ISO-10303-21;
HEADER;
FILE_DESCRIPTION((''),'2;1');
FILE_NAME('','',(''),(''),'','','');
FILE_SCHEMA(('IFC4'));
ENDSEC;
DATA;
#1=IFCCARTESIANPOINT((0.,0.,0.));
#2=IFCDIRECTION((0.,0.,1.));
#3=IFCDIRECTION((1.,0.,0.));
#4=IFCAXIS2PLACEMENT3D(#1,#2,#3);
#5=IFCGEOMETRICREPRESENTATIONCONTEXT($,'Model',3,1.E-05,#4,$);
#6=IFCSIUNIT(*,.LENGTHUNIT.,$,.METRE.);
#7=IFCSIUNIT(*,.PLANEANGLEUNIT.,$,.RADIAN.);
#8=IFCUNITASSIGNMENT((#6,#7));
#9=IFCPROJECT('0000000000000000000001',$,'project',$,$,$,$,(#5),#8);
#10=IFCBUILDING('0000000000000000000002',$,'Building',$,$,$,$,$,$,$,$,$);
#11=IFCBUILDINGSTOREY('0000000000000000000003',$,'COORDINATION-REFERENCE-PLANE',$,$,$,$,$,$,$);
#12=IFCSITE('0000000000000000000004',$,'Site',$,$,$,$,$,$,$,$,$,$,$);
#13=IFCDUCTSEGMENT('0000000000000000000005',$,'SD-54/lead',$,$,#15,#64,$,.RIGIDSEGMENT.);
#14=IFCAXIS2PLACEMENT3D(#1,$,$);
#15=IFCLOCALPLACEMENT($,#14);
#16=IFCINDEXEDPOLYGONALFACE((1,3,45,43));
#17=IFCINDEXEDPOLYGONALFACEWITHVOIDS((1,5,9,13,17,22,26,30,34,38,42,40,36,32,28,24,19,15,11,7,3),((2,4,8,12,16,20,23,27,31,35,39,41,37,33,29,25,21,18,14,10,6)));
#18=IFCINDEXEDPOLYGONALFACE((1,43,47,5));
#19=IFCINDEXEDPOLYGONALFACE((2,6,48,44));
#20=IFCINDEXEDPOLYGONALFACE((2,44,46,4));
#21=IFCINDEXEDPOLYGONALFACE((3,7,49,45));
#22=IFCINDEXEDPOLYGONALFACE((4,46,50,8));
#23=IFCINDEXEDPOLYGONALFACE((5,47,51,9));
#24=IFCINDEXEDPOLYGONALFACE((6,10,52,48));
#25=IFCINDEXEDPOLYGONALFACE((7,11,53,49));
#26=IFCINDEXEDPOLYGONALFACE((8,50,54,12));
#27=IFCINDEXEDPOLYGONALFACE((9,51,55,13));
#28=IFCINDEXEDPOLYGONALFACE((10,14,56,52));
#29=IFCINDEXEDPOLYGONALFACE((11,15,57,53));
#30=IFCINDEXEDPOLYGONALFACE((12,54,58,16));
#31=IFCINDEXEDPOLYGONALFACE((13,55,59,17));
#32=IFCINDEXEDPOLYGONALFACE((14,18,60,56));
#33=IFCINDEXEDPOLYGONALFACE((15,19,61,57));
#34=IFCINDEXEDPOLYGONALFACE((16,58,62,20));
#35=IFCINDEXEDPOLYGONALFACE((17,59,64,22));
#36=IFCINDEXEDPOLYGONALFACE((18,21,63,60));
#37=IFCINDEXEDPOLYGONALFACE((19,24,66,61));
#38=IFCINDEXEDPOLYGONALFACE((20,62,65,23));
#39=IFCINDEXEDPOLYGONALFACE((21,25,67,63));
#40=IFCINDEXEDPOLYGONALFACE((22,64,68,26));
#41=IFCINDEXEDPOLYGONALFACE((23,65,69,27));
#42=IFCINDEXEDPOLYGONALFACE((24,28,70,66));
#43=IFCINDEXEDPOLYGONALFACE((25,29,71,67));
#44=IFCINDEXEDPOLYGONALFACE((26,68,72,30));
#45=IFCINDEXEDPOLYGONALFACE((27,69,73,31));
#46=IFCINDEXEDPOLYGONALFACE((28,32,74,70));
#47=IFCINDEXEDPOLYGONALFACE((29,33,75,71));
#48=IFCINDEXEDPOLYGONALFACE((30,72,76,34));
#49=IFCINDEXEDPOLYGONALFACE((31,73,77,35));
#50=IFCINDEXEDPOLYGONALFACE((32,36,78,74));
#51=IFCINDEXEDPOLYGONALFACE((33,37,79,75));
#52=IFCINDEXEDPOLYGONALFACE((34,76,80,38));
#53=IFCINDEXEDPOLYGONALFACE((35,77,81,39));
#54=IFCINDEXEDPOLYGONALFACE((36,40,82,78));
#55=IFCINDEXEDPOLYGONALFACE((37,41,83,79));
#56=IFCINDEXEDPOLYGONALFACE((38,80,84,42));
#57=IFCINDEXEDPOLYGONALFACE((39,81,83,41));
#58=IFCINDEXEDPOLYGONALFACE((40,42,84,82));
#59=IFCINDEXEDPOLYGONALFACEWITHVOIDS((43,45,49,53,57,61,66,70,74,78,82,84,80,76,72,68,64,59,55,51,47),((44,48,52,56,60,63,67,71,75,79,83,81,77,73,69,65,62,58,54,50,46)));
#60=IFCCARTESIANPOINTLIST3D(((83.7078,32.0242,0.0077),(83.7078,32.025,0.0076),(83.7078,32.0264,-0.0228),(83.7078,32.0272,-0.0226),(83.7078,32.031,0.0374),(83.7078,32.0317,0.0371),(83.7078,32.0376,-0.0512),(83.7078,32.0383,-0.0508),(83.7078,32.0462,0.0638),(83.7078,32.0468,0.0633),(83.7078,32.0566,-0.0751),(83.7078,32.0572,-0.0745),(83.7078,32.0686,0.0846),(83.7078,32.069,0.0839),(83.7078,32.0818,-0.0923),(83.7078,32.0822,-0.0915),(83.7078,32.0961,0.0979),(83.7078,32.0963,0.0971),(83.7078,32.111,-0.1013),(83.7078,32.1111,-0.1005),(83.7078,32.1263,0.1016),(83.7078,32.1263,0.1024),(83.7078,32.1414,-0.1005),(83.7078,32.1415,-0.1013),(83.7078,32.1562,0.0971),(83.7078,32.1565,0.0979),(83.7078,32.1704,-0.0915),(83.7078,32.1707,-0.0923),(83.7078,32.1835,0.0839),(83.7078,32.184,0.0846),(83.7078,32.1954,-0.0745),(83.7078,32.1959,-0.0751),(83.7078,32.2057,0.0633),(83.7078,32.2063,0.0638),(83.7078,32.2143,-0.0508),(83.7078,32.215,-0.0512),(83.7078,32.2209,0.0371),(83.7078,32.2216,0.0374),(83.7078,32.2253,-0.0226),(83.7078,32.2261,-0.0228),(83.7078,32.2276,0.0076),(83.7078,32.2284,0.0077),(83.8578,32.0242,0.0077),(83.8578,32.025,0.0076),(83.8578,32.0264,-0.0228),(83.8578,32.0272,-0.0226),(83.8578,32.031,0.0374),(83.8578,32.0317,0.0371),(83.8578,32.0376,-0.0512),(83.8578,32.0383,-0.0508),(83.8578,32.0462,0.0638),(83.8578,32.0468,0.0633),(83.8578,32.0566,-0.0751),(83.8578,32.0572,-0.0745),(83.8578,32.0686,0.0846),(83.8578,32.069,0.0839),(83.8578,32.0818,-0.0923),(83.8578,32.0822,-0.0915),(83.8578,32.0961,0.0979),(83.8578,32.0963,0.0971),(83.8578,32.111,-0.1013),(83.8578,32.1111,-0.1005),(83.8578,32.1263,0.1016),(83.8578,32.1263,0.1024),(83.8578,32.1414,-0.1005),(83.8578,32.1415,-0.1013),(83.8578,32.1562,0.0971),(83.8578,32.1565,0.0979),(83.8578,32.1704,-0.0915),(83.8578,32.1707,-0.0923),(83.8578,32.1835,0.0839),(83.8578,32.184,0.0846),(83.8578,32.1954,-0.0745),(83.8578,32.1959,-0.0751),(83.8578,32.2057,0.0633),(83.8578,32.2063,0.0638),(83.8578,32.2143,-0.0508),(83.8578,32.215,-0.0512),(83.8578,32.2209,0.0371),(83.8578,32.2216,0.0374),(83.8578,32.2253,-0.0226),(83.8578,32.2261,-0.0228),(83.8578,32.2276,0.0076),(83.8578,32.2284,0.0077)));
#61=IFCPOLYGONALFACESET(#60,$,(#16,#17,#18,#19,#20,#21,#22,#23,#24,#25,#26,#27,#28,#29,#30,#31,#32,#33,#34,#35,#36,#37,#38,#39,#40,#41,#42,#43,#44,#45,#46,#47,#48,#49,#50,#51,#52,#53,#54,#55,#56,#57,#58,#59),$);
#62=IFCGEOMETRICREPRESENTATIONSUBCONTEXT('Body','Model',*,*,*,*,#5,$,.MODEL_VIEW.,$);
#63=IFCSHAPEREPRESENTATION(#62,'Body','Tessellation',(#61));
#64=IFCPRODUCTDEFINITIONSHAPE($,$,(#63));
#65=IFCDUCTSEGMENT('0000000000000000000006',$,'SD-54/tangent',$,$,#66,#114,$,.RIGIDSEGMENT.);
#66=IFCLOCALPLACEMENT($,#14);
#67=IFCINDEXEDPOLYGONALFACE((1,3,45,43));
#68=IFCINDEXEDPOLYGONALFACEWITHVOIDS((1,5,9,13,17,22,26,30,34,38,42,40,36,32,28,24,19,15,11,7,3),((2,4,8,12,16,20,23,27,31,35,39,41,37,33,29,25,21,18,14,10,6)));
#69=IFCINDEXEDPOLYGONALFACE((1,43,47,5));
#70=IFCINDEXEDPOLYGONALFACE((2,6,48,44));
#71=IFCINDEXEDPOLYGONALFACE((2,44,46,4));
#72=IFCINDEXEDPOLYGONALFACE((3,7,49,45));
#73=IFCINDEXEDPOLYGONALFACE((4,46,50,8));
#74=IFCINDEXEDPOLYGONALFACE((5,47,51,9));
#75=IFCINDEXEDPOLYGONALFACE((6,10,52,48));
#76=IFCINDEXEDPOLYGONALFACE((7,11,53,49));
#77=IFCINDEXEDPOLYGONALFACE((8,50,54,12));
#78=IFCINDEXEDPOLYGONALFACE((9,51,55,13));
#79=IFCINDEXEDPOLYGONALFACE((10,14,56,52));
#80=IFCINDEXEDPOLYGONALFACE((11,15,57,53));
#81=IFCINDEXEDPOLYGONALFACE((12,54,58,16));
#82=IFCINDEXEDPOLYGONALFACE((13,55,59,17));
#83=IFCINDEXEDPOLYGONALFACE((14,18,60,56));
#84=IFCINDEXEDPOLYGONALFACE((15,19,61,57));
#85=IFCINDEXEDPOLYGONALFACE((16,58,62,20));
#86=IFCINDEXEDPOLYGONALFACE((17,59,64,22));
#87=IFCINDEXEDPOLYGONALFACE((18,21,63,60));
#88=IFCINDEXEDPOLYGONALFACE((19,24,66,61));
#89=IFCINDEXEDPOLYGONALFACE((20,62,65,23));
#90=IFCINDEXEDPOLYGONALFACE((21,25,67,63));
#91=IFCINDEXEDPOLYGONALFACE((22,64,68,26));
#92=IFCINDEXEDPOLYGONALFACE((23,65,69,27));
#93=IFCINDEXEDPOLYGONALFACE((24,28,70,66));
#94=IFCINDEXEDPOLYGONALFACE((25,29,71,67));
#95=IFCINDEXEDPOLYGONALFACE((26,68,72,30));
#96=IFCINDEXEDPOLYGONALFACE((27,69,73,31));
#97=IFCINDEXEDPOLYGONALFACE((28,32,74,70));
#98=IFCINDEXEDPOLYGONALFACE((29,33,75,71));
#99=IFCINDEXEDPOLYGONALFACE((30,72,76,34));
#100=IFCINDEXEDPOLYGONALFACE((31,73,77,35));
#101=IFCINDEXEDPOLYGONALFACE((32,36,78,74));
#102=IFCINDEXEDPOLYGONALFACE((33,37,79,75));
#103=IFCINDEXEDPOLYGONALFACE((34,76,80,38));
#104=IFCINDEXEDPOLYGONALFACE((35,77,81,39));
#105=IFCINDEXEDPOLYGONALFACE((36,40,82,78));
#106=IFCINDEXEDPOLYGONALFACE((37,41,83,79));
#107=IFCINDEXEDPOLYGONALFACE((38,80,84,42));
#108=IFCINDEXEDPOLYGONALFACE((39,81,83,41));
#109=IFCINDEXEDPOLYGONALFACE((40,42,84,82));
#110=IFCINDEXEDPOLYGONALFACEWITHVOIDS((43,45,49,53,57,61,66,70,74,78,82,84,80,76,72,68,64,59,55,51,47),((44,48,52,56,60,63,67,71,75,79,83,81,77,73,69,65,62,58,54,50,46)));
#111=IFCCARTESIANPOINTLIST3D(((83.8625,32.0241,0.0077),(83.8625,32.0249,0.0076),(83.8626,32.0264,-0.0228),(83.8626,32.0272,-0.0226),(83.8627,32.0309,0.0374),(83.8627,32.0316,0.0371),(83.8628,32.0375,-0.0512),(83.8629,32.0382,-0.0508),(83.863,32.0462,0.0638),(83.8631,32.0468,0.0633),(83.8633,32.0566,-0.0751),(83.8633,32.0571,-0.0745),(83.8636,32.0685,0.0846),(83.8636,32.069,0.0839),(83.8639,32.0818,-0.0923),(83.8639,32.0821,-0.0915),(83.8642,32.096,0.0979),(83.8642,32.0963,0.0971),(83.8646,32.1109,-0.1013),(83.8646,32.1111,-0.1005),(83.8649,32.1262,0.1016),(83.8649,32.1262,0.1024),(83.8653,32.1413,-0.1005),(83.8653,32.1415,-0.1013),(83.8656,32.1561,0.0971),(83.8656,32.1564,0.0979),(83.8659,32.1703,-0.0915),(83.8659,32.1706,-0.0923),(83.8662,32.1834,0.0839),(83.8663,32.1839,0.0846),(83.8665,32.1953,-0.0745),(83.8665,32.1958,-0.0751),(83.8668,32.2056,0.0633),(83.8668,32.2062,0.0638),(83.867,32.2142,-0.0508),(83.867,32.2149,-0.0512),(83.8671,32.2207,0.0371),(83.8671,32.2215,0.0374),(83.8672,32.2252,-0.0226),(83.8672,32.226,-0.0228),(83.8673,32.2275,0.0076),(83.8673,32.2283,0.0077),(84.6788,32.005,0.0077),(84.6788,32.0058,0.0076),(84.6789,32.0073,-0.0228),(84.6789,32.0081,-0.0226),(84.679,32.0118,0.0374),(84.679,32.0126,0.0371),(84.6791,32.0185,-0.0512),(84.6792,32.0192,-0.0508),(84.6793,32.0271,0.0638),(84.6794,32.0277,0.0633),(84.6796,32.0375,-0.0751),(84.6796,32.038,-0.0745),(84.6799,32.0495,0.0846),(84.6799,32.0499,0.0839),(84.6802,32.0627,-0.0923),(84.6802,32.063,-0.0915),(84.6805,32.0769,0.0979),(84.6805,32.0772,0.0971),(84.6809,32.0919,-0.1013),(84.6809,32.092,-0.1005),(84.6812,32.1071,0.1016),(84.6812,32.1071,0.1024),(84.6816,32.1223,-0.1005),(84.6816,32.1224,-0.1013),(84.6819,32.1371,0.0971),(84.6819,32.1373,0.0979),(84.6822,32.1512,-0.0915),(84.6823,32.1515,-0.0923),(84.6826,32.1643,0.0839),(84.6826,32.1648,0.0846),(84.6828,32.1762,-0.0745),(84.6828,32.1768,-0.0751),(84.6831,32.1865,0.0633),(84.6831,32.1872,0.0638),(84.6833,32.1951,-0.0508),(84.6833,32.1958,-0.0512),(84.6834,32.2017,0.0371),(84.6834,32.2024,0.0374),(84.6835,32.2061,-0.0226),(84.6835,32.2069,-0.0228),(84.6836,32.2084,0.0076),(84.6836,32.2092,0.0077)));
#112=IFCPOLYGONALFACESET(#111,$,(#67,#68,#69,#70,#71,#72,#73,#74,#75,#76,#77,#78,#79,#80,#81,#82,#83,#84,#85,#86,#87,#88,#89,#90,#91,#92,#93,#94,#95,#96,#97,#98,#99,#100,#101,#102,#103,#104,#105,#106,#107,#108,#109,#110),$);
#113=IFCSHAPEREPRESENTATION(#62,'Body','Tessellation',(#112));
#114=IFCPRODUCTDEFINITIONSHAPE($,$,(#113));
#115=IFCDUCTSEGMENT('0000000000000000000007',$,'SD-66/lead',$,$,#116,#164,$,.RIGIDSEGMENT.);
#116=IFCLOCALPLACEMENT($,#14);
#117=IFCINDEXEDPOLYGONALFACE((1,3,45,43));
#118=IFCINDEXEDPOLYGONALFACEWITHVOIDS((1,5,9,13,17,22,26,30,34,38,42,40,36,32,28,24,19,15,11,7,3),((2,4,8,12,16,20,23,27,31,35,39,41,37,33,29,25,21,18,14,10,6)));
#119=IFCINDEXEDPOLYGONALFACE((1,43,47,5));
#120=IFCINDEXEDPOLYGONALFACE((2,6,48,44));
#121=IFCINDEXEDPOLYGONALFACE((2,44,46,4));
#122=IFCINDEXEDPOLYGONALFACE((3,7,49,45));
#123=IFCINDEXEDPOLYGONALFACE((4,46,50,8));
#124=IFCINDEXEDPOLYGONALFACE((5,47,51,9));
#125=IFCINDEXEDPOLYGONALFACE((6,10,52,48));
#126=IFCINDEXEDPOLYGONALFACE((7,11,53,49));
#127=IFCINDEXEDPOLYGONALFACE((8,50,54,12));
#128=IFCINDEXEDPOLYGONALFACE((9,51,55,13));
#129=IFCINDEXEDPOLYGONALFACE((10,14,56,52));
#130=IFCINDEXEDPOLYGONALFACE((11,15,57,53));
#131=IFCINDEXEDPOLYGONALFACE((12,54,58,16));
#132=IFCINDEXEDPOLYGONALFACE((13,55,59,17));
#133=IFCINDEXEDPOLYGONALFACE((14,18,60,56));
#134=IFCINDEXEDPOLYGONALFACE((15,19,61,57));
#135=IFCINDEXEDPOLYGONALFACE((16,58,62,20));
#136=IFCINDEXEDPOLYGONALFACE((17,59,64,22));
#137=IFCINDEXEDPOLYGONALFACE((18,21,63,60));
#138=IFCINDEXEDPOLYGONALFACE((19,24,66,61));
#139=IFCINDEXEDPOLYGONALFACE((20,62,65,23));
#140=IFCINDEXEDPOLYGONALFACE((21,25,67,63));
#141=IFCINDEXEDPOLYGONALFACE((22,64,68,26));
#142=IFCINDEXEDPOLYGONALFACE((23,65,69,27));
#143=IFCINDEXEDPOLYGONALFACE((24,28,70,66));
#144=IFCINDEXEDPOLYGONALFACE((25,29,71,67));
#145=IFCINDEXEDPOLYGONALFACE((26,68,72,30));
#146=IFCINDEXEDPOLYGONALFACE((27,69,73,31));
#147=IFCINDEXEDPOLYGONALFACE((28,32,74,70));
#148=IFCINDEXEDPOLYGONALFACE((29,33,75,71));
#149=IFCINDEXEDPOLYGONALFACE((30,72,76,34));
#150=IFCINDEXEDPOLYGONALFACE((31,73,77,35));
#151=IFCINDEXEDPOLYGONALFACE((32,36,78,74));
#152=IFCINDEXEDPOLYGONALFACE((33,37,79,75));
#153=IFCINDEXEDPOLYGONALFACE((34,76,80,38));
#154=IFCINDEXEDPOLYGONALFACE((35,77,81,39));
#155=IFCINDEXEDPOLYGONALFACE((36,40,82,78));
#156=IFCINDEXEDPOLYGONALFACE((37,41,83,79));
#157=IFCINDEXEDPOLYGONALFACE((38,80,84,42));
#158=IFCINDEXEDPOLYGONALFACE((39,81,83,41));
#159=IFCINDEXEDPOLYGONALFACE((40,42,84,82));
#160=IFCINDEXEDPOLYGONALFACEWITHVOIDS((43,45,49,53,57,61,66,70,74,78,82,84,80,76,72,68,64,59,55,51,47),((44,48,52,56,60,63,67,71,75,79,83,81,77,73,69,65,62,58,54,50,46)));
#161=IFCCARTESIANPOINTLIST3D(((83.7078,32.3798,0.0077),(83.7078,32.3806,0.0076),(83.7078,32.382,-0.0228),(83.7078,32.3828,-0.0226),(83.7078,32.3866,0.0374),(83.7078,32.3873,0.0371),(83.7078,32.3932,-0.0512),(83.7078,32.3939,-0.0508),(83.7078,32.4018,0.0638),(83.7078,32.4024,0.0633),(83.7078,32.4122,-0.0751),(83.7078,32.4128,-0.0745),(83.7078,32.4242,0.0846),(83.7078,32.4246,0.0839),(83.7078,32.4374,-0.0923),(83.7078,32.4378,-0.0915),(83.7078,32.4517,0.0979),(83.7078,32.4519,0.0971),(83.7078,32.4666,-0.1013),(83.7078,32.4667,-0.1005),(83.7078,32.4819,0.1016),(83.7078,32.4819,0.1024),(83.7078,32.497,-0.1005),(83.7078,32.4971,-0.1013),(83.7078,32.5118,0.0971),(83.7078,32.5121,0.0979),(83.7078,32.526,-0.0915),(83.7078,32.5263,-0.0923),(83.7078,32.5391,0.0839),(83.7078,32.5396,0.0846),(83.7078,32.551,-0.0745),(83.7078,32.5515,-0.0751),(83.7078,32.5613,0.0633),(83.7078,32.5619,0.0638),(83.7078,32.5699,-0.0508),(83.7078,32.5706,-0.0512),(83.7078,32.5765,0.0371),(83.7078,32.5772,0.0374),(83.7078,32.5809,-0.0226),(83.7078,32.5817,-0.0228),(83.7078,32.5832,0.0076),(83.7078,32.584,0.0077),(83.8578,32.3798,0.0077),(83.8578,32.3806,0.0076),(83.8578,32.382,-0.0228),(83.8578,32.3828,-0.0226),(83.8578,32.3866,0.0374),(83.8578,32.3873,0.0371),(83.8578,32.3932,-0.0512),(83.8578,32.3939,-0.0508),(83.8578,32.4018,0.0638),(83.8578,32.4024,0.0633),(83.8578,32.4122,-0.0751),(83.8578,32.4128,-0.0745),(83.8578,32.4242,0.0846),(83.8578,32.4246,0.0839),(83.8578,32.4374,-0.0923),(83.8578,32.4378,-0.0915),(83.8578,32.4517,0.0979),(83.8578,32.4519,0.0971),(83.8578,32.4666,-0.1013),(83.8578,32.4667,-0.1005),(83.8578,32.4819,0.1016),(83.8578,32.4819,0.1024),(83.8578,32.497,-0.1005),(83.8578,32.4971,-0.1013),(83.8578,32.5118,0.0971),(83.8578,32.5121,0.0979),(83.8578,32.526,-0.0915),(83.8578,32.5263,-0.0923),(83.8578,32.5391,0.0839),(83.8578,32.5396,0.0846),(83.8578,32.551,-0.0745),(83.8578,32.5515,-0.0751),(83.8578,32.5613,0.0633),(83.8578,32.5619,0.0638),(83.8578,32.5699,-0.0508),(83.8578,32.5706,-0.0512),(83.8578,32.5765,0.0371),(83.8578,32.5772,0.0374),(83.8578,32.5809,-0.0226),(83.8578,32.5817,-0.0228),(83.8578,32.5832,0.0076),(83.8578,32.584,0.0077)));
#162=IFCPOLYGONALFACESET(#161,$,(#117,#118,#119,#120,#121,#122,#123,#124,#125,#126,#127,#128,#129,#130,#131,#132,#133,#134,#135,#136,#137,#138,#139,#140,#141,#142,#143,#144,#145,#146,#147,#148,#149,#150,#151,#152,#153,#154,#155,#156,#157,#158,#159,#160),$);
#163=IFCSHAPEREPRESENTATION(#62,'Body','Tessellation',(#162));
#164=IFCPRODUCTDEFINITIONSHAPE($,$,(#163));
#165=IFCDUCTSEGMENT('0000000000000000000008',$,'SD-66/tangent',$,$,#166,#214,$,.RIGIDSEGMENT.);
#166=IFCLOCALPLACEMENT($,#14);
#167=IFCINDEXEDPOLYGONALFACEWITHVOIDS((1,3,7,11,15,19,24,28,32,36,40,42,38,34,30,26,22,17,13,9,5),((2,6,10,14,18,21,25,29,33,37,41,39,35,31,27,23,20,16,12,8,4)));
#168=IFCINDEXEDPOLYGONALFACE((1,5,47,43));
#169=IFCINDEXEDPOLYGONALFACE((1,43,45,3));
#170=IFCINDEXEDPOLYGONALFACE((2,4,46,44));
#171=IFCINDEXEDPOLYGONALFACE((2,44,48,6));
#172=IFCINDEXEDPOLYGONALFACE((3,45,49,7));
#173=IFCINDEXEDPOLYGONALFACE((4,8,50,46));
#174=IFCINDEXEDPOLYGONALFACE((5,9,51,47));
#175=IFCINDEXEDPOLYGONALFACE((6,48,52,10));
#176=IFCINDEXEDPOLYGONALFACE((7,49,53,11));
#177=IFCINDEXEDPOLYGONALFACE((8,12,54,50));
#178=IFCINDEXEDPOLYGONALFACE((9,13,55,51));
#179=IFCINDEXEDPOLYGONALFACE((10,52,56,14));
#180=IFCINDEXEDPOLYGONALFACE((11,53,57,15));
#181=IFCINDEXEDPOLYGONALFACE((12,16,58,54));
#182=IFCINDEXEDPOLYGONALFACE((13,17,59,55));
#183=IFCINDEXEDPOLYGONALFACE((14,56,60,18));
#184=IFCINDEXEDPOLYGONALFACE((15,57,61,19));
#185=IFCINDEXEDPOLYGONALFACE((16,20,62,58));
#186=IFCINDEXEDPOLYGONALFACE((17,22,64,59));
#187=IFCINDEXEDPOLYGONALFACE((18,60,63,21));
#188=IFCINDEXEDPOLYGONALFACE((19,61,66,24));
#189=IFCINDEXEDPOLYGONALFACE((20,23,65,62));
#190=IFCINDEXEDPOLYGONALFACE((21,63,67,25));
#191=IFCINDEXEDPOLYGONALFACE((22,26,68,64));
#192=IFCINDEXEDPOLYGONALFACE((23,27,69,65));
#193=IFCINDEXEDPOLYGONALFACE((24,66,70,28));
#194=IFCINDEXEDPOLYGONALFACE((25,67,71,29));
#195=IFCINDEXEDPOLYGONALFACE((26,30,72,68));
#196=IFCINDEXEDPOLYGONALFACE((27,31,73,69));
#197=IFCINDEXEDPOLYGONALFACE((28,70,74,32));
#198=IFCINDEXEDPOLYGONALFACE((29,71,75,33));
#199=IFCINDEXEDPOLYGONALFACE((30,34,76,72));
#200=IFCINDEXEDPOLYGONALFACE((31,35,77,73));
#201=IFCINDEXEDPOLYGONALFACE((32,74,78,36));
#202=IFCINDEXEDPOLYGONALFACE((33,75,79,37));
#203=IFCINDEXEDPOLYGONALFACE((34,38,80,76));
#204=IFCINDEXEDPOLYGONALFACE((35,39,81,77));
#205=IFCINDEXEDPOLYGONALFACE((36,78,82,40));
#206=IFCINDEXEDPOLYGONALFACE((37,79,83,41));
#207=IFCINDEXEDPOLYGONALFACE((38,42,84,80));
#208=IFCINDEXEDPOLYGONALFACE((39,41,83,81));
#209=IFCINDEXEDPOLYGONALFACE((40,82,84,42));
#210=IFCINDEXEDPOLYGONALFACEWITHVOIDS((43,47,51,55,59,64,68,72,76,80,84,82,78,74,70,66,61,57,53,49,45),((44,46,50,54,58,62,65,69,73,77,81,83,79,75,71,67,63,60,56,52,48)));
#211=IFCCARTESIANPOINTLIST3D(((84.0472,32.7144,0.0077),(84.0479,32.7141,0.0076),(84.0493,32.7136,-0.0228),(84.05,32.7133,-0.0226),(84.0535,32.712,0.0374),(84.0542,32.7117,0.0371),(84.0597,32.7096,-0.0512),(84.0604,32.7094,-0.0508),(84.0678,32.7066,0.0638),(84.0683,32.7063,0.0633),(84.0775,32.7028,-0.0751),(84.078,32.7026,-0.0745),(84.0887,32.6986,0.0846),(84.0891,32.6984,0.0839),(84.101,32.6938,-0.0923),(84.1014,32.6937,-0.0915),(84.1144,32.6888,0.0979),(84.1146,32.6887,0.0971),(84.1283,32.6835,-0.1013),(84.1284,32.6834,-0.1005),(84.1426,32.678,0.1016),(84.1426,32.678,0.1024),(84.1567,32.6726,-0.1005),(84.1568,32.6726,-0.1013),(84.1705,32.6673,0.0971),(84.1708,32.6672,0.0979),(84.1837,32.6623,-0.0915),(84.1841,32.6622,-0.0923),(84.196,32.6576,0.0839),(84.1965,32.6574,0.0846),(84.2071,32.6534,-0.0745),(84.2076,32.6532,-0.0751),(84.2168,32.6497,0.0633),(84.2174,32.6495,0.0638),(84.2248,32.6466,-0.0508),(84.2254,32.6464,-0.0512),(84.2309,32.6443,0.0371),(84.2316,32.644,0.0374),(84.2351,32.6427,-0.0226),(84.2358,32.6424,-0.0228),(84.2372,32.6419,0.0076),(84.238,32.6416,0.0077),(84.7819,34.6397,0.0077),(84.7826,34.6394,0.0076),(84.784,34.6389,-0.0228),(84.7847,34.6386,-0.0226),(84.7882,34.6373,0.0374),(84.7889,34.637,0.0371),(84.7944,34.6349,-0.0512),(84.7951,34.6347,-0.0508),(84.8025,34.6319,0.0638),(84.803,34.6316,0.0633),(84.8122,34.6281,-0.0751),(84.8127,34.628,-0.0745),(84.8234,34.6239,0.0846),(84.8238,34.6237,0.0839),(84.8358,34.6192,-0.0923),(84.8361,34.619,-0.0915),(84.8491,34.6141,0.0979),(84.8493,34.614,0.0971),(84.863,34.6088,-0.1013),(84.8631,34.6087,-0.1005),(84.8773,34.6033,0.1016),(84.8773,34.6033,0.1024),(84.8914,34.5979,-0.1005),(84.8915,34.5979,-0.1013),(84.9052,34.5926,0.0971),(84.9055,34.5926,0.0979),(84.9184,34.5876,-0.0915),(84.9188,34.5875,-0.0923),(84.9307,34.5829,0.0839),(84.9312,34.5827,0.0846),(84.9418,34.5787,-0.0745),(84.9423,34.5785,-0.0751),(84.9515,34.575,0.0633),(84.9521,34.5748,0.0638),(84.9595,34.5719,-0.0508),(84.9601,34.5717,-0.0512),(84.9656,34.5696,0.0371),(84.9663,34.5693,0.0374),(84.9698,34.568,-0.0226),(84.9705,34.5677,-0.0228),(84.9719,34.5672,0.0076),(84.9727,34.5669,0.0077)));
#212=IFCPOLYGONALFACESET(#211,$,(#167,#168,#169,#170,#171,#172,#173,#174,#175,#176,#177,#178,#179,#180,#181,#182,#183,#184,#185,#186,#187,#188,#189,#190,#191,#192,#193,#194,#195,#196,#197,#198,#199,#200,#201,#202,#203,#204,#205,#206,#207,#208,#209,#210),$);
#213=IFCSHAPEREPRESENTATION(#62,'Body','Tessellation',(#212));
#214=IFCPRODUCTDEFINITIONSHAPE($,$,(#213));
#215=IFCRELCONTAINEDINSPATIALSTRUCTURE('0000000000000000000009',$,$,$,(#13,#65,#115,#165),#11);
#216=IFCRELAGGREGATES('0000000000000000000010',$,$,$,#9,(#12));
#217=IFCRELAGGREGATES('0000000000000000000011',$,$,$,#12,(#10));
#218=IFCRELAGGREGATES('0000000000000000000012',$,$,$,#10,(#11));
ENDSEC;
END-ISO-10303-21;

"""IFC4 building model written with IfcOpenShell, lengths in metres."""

from ifc_helpers import new_model, si_unit, frame, origin_with_axes, place, context, subcontext, project, spatial, hollow_circle, extrude, element, save


model = new_model("IFC4")

# Units and contexts
model_context = context("Model", 3, precision=1e-05, world=origin_with_axes())
body_context = subcontext(model_context, "Body", "Model", "MODEL_VIEW")
ifc_project = project(units=[si_unit("LENGTHUNIT", "METRE"), si_unit("PLANEANGLEUNIT", "RADIAN")], contexts=[model_context])

# Site, building, storey
site = spatial("IfcSite", under=ifc_project, Name="Site")
building = spatial("IfcBuilding", under=site, Name="Building")
storey = spatial("IfcBuildingStorey", under=building, Name="COORDINATION-REFERENCE-PLANE")

# Duct segment
duct_segment_1_placement = place(None, frame((83.7078, 32.1263, 0.0), z_axis=(1.0, 0.0, 0.0), x_axis=(0.0, 0.0, 1.0)))
element("IfcDuctSegment", 1, at=duct_segment_1_placement, inside=storey, Name="SD-54/lead", PredefinedType="RIGIDSEGMENT", context=body_context, shape_type="SweptSolid", body=[
    extrude(hollow_circle(Radius=0.1024, WallThickness=0.0008), origin_with_axes(), (0.0, 0.0, 1.0), 0.15),
])

# Duct segment
duct_segment_2_placement = place(None, frame((83.8649, 32.1262, 0.0), z_axis=(0.999727, -0.023361, 0.0), x_axis=(0.0, 0.0, 1.0)))
element("IfcDuctSegment", 2, at=duct_segment_2_placement, inside=storey, Name="SD-54/tangent", PredefinedType="RIGIDSEGMENT", context=body_context, shape_type="SweptSolid", body=[
    extrude(hollow_circle(Radius=0.1024, WallThickness=0.0008), origin_with_axes(), (0.0, 0.0, 1.0), 0.8165),
])

# Duct segment
duct_segment_3_placement = place(None, frame((83.7078, 32.4819, 0.0), z_axis=(1.0, 0.0, 0.0), x_axis=(0.0, 0.0, 1.0)))
element("IfcDuctSegment", 3, at=duct_segment_3_placement, inside=storey, Name="SD-66/lead", PredefinedType="RIGIDSEGMENT", context=body_context, shape_type="SweptSolid", body=[
    extrude(hollow_circle(Radius=0.1024, WallThickness=0.0008), origin_with_axes(), (0.0, 0.0, 1.0), 0.15),
])

# Duct segment
duct_segment_4_placement = place(None, frame((84.1426, 32.678, 0.0), z_axis=(0.356527, 0.934285, 0.0), x_axis=(0.0, 0.0, 1.0)))
element("IfcDuctSegment", 4, at=duct_segment_4_placement, inside=storey, Name="SD-66/tangent", PredefinedType="RIGIDSEGMENT", context=body_context, shape_type="SweptSolid", body=[
    extrude(hollow_circle(Radius=0.1024, WallThickness=0.0008), origin_with_axes(), (0.0, 0.0, 1.0), 2.0607),
])

save(model, "model.ifc")
